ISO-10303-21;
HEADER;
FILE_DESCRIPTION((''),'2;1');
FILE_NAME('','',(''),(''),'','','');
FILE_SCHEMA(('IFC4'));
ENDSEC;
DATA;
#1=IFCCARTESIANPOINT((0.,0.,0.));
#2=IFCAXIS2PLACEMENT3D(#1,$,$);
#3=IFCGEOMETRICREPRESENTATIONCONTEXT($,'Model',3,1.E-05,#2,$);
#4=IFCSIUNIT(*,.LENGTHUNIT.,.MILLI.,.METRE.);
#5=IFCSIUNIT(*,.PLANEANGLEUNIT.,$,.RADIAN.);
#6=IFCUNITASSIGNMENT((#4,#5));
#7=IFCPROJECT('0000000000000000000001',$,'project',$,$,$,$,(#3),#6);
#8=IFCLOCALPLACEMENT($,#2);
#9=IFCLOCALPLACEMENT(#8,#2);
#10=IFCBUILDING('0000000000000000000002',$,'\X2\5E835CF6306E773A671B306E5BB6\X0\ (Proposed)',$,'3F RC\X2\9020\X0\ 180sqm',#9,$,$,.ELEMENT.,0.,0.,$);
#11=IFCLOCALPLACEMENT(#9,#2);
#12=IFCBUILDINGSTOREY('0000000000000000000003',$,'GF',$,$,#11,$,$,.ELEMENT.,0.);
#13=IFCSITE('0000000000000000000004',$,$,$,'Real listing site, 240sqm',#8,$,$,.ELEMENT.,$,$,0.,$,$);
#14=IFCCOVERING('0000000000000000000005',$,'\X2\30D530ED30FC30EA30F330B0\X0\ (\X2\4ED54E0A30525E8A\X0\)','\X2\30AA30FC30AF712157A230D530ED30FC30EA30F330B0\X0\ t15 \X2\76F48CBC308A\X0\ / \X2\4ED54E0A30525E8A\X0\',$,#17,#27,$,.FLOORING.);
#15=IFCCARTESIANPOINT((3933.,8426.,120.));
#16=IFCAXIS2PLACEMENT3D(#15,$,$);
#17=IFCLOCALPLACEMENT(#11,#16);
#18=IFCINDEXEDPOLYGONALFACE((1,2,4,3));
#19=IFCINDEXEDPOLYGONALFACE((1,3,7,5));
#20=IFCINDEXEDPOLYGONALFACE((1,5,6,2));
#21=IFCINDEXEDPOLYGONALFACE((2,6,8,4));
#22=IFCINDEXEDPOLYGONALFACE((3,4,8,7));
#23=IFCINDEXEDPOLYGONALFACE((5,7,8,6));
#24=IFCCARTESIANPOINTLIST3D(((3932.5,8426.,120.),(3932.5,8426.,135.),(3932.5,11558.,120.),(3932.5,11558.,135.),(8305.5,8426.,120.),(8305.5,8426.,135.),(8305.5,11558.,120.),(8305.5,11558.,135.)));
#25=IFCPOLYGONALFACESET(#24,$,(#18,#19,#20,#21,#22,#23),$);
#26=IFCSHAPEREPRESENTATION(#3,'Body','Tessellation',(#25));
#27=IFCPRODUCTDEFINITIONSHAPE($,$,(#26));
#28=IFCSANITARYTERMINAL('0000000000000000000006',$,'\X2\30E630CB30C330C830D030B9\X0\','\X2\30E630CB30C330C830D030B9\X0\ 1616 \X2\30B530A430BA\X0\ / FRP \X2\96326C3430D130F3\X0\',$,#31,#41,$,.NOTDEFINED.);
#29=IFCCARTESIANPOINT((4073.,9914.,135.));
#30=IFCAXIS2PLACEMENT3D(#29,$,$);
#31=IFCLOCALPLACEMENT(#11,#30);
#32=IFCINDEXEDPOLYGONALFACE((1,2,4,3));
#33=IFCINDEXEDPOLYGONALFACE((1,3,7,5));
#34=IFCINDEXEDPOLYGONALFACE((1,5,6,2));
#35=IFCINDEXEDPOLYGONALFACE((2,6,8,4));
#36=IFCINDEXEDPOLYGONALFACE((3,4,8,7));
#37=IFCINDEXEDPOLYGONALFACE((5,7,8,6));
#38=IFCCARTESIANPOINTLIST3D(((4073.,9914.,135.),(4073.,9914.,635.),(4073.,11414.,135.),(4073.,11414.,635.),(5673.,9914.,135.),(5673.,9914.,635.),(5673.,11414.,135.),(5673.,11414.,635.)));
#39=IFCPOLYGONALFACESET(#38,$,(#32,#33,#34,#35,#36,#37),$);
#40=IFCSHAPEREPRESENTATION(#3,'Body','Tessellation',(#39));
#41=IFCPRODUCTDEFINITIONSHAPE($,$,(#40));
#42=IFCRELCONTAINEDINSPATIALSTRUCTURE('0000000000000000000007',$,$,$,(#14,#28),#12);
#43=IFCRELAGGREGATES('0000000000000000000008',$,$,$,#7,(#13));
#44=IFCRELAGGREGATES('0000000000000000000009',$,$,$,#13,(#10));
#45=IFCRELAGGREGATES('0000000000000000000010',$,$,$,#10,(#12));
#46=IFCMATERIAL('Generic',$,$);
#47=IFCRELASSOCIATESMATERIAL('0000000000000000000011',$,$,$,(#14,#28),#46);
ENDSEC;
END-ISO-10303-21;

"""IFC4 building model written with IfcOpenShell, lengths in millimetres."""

from ifc_helpers import new_model, si_unit, frame, frame_2d, origin, place, context, project, spatial, rectangle, extrude, material, element, save


model = new_model("IFC4")

# Units and contexts
model_context = context("Model", 3, precision=1e-05, world=origin())
ifc_project = project(units=[si_unit("LENGTHUNIT", "METRE", prefix="MILLI"), si_unit("PLANEANGLEUNIT", "RADIAN")], contexts=[model_context])

# Site, building, storey
site_placement = place(None, origin())
site = spatial("IfcSite", under=ifc_project, at=site_placement, ObjectType="Real listing site, 240sqm", CompositionType="ELEMENT", RefElevation=0.0)
building_placement = place(site_placement, origin())
building = spatial("IfcBuilding", under=site, at=building_placement, Name="広島の眺望の家 (Proposed)", ObjectType="3F RC造 180sqm", CompositionType="ELEMENT", ElevationOfRefHeight=0.0, ElevationOfTerrain=0.0)
storey_placement = place(building_placement, origin())
storey = spatial("IfcBuildingStorey", under=building, at=storey_placement, Name="GF", CompositionType="ELEMENT", Elevation=0.0)

# Covering
ifc_material_1 = material(Name="Generic")
covering_1_placement = place(storey_placement, frame((3933.0, 8426.0, 120.0)))
element("IfcCovering", 1, at=covering_1_placement, inside=storey, material=ifc_material_1, Name="フローリング (仕上げ床)", Description="オーク無垢フローリング t15 直貼り / 仕上げ床", PredefinedType="FLOORING", context=model_context, shape_type="SweptSolid", body=[
    extrude(rectangle(XDim=4373.0, YDim=3132.0, at=frame_2d((2186.0, 1566.0))), frame((3933.0, 8426.0, 120.0)), (0.0, 0.0, 1.0), 15.0),
])

# Sanitary terminal
sanitary_terminal_placement = place(storey_placement, frame((4073.0, 9914.0, 135.0)))
element("IfcSanitaryTerminal", 2, at=sanitary_terminal_placement, inside=storey, material=ifc_material_1, Name="ユニットバス", Description="ユニットバス 1616 サイズ / FRP 防水パン", PredefinedType="NOTDEFINED", context=model_context, shape_type="SweptSolid", body=[
    extrude(rectangle(XDim=1600.0, YDim=1500.0, at=frame_2d((800.0, 750.0))), frame((4073.0, 9914.0, 135.0)), (0.0, 0.0, 1.0), 500.0),
])

save(model, "model.ifc")
